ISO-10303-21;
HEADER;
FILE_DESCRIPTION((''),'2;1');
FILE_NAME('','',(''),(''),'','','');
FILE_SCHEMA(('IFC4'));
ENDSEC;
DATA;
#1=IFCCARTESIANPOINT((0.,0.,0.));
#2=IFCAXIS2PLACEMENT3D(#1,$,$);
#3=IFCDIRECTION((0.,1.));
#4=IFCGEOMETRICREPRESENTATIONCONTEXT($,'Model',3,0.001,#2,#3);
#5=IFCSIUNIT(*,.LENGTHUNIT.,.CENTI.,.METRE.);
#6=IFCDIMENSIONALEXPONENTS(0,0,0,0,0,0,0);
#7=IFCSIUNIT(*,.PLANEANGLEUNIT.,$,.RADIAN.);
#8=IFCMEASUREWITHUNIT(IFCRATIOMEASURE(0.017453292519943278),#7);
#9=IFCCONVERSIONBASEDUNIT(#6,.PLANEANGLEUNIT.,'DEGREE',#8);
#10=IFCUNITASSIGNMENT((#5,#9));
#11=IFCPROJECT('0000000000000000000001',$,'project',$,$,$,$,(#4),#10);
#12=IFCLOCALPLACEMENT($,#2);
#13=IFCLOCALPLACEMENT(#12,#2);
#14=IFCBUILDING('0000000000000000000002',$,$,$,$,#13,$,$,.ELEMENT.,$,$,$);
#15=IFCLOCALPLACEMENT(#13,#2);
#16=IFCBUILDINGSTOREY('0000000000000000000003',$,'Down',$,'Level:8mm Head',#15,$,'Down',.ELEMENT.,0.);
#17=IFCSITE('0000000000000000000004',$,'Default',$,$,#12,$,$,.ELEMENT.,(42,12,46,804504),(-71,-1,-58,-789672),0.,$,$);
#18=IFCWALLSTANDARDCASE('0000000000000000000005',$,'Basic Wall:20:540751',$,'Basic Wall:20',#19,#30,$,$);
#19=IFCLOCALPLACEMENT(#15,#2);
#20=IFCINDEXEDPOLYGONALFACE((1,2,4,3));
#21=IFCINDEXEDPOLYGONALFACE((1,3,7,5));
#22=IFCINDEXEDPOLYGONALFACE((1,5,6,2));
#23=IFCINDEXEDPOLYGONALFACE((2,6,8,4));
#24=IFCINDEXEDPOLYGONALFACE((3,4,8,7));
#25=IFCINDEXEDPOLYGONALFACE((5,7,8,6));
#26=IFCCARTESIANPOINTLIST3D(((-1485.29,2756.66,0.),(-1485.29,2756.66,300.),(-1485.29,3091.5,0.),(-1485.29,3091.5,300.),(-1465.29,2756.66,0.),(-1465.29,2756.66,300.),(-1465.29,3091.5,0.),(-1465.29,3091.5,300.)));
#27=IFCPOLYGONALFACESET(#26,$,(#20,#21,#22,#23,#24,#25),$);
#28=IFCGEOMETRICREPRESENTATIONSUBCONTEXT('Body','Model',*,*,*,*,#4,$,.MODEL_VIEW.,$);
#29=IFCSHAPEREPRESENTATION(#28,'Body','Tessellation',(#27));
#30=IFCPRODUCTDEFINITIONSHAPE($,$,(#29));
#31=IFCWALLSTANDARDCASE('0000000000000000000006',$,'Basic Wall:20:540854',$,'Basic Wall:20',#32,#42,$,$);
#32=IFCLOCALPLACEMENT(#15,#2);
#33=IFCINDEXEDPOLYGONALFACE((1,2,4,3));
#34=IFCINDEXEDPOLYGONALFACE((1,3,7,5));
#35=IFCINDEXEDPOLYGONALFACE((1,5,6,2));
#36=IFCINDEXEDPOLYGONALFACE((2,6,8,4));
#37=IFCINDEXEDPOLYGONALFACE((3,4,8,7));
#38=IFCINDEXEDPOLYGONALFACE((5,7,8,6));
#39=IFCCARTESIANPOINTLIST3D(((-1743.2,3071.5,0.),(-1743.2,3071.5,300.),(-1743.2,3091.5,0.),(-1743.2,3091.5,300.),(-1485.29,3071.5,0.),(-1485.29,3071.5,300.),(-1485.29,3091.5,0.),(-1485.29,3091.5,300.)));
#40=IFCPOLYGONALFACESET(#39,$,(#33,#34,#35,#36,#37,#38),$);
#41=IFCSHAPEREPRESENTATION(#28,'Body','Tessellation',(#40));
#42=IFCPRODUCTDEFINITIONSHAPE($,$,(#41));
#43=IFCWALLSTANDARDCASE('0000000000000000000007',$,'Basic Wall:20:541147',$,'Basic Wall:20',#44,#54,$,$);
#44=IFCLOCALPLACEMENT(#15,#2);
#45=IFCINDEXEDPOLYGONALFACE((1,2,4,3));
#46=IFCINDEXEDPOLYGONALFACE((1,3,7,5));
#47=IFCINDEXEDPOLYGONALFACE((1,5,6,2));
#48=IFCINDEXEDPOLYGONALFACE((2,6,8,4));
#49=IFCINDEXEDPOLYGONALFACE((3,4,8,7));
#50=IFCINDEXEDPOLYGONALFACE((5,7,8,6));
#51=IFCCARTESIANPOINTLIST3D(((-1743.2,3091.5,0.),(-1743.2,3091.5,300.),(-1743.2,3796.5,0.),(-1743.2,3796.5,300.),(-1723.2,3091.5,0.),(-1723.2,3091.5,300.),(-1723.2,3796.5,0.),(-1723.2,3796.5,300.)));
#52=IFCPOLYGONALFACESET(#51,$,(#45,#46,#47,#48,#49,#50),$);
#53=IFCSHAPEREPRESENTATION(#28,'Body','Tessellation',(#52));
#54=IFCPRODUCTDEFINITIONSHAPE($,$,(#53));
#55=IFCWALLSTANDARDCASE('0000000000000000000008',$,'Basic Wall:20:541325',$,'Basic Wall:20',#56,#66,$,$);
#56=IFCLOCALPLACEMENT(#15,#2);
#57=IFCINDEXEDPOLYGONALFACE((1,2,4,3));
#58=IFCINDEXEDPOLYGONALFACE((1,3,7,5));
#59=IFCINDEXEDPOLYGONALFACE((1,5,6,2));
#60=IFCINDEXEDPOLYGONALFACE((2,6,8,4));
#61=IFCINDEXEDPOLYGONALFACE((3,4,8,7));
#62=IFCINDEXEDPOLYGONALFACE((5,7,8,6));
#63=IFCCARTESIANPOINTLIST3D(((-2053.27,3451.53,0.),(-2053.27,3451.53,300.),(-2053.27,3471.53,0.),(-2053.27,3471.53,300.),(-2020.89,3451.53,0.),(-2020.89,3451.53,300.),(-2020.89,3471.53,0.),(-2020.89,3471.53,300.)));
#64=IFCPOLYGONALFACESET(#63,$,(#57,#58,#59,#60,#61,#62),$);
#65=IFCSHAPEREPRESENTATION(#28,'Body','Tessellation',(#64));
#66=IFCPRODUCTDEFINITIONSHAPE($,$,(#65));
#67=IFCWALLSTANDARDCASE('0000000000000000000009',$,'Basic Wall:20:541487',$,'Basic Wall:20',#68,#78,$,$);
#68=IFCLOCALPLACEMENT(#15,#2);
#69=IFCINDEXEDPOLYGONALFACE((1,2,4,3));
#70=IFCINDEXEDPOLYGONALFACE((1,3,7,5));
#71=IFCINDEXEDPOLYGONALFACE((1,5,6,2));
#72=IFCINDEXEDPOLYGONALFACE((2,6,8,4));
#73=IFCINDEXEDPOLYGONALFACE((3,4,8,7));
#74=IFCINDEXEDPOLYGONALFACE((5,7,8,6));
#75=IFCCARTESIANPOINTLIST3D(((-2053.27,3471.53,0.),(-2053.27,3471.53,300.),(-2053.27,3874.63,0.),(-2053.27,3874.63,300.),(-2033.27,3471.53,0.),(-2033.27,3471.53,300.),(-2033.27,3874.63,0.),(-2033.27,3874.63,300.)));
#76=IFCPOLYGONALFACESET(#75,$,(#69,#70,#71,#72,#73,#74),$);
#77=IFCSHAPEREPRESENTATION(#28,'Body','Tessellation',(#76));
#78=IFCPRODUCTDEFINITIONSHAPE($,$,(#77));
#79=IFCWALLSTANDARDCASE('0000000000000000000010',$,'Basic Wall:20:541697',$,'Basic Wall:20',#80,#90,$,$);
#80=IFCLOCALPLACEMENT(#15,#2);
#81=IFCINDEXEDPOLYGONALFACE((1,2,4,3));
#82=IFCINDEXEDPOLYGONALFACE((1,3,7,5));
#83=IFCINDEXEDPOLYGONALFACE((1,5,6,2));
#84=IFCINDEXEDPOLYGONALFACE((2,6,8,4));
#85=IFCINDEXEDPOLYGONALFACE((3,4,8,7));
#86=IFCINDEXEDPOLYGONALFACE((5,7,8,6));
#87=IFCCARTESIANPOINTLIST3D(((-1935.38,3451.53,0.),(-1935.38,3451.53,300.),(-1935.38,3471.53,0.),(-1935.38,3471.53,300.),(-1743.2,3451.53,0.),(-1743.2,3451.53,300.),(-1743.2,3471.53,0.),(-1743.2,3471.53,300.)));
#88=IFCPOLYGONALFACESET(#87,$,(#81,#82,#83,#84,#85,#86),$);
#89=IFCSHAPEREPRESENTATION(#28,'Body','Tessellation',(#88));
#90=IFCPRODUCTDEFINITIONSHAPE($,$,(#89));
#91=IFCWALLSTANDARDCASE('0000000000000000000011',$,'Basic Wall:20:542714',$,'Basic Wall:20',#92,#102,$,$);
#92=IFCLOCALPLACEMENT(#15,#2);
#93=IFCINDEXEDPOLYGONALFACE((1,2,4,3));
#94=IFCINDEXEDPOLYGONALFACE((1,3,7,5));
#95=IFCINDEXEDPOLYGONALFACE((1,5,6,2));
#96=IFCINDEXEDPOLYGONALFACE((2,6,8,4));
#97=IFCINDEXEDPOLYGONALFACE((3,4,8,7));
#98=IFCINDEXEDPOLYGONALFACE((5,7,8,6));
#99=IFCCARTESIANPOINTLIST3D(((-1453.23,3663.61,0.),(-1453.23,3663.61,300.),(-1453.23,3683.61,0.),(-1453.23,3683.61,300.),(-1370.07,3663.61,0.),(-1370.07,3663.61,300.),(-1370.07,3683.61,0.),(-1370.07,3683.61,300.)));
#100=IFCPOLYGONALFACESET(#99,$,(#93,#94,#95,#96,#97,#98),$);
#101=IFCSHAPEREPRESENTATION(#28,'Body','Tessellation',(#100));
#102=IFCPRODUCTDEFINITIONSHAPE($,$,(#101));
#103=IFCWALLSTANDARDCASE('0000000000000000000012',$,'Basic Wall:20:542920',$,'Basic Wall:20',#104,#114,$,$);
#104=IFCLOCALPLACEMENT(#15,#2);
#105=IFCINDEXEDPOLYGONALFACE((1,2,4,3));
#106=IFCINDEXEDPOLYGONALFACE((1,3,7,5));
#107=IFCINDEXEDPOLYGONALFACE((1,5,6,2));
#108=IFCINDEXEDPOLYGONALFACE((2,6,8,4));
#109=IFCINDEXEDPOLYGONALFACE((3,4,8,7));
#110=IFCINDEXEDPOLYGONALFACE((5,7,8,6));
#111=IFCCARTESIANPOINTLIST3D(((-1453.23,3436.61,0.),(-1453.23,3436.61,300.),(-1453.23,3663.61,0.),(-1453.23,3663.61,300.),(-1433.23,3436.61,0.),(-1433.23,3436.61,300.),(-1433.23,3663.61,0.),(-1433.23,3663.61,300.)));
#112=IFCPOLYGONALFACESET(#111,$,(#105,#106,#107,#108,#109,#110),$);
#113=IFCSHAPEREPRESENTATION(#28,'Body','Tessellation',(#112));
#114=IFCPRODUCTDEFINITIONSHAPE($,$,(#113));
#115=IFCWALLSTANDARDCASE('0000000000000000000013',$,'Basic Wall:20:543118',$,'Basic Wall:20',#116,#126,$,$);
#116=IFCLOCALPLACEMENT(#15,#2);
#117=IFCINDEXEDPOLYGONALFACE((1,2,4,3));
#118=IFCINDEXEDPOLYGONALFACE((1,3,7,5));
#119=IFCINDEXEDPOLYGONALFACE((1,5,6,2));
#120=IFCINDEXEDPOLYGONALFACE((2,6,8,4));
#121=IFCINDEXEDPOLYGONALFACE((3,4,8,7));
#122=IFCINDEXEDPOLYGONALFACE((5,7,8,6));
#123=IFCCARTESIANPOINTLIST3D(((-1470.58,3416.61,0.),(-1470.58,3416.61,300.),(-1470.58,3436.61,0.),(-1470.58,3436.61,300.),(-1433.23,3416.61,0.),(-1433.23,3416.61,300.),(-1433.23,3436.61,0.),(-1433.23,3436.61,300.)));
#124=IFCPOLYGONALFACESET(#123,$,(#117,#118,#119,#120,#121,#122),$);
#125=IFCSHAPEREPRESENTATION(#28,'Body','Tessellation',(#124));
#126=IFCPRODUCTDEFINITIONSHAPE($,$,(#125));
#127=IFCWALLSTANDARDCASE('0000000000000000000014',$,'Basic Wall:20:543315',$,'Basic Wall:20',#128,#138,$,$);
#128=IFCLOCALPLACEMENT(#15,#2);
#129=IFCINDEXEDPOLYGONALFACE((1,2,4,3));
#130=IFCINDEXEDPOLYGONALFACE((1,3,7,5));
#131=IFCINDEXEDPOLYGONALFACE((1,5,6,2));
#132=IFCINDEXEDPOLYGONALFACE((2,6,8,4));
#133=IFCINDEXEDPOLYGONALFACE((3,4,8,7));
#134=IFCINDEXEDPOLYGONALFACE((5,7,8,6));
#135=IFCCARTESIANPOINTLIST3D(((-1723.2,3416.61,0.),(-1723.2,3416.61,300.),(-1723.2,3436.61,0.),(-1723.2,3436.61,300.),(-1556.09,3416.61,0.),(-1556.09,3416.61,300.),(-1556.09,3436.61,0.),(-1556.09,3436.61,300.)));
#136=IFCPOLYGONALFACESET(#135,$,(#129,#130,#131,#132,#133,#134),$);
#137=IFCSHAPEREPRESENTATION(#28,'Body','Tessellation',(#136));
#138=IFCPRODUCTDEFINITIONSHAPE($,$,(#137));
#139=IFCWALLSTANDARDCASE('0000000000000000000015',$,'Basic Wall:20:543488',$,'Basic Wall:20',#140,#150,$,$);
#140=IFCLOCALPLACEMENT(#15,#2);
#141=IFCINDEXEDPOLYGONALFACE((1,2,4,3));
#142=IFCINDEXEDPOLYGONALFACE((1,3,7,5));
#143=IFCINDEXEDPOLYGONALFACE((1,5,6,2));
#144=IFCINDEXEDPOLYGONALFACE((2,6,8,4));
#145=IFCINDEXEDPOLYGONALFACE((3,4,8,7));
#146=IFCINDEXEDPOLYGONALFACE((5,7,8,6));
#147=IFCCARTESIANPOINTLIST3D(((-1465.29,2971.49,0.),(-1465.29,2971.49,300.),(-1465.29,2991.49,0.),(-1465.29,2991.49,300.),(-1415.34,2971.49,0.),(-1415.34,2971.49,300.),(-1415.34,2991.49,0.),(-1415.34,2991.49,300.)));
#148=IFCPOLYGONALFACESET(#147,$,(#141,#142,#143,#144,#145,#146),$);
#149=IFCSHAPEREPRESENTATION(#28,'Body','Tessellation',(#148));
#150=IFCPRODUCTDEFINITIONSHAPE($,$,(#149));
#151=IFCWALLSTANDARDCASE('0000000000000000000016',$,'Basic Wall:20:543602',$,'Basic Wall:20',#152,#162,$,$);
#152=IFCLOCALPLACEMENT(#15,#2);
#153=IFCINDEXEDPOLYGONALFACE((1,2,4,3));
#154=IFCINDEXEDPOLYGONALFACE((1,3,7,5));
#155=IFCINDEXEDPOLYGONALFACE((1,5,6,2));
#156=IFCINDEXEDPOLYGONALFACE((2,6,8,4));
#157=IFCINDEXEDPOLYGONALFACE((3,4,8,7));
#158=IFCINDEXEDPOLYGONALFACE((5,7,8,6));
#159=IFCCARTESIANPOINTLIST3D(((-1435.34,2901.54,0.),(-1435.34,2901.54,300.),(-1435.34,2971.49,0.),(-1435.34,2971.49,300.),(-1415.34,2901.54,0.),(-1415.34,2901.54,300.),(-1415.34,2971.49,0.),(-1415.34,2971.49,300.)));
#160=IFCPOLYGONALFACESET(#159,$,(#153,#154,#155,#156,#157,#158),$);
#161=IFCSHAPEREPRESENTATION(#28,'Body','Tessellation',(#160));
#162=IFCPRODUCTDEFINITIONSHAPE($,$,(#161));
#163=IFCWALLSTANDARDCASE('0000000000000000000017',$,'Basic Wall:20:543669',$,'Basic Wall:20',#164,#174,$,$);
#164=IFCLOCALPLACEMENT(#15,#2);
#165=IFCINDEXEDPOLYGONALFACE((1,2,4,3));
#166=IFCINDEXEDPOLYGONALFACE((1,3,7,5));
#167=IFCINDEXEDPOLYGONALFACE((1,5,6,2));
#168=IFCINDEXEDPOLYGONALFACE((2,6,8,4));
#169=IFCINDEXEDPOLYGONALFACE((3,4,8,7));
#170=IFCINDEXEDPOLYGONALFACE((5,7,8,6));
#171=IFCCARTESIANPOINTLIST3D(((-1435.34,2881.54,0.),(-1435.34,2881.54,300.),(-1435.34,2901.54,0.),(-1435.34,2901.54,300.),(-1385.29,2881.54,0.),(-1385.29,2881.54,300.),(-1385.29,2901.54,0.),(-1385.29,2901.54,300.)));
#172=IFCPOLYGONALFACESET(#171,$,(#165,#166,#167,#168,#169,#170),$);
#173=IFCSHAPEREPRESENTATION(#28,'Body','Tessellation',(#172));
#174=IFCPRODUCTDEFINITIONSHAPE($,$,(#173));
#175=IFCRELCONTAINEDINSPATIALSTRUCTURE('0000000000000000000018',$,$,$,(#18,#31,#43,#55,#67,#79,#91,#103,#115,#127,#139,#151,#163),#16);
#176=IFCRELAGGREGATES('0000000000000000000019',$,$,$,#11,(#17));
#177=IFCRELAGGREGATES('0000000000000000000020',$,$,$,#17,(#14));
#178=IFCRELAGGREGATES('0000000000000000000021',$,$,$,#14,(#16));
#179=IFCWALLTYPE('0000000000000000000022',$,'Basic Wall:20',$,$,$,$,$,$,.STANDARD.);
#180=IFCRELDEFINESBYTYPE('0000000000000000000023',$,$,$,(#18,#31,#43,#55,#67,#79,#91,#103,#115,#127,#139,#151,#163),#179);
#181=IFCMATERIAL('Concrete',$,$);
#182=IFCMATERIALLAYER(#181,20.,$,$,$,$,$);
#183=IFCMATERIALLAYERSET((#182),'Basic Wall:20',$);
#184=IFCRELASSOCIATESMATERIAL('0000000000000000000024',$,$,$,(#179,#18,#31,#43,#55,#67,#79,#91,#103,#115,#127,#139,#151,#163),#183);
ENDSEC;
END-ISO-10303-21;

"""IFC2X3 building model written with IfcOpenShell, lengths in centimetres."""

from ifc_helpers import new_model, entity, si_unit, converted_unit, direction, frame, frame_2d, origin, place, context, subcontext, project, spatial, rectangle, extrude, material, layer, layer_set, layer_usage, type_object, element, save


model = new_model("IFC2X3")

# Units and contexts
model_context = context("Model", 3, precision=0.001, world=origin(), true_north=direction((0.0, 1.0)))
body_context = subcontext(model_context, "Body", "Model", "MODEL_VIEW")
ifc_project = project(units=[si_unit("LENGTHUNIT", "METRE", prefix="CENTI"), converted_unit("PLANEANGLEUNIT", "DEGREE", entity("IfcRatioMeasure", 0.017453292519943278), si_unit("PLANEANGLEUNIT", "RADIAN"), dimensions=[0, 0, 0, 0, 0, 0, 0])], contexts=[model_context])

# Site, building, storey
site_placement = place(None, origin())
site = spatial("IfcSite", under=ifc_project, at=site_placement, Name="Default", CompositionType="ELEMENT", RefLatitude=(42, 12, 46, 804504), RefLongitude=(-71, -1, -58, -789672), RefElevation=0.0)
building_placement = place(site_placement, origin())
building = spatial("IfcBuilding", under=site, at=building_placement, CompositionType="ELEMENT")
storey_placement = place(building_placement, origin())
storey = spatial("IfcBuildingStorey", under=building, at=storey_placement, Name="Down", ObjectType="Level:8mm Head", LongName="Down", CompositionType="ELEMENT", Elevation=0.0)

# Walls
ifc_material = material(Name="Concrete")
ifc_layer_1 = layer(ifc_material, 20.0)
ifc_layer_set_1 = layer_set([ifc_layer_1], Name="Basic Wall:20")
ifc_layer_usage_1 = layer_usage(ifc_layer_set_1, "AXIS2", "POSITIVE", -10.0)
wall_type_1 = type_object("IfcWallType", Name="Basic Wall:20", PredefinedType="STANDARD", material=ifc_layer_set_1)
wall_1_placement = place(storey_placement, frame((-1475.29, 2756.66, 0.0), z_axis=(0.0, 0.0, 1.0), x_axis=(0.0, 1.0, 0.0)))
element("IfcWallStandardCase", 1, at=wall_1_placement, inside=storey, type_object=wall_type_1, material=ifc_layer_usage_1, Name="Basic Wall:20:540751", ObjectType="Basic Wall:20", context=body_context, shape_type="SweptSolid", body=[
    extrude(rectangle(XDim=334.84, YDim=20.0, at=frame_2d((167.42, 0.0), x_axis=(-1.0, 0.0))), origin(), (0.0, 0.0, 1.0), 300.0),
])
ifc_layer_usage_2 = layer_usage(ifc_layer_set_1, "AXIS2", "POSITIVE", -10.0)
wall_2_placement = place(storey_placement, frame((-1485.29, 3081.5, 0.0), z_axis=(0.0, 0.0, 1.0), x_axis=(-1.0, 0.0, 0.0)))
element("IfcWallStandardCase", 2, at=wall_2_placement, inside=storey, type_object=wall_type_1, material=ifc_layer_usage_2, Name="Basic Wall:20:540854", ObjectType="Basic Wall:20", context=body_context, shape_type="SweptSolid", body=[
    extrude(rectangle(XDim=257.9, YDim=20.0, at=frame_2d((128.95, 0.0), x_axis=(-1.0, 0.0))), origin(), (0.0, 0.0, 1.0), 300.0),
])
ifc_layer_usage_3 = layer_usage(ifc_layer_set_1, "AXIS2", "NEGATIVE", 10.0)
wall_3_placement = place(storey_placement, frame((-1733.2, 3091.5, 0.0), z_axis=(0.0, 0.0, 1.0), x_axis=(0.0, 1.0, 0.0)))
element("IfcWallStandardCase", 3, at=wall_3_placement, inside=storey, type_object=wall_type_1, material=ifc_layer_usage_3, Name="Basic Wall:20:541147", ObjectType="Basic Wall:20", context=body_context, shape_type="SweptSolid", body=[
    extrude(rectangle(XDim=705.0, YDim=20.0, at=frame_2d((352.5, 0.0), x_axis=(-1.0, 0.0))), origin(), (0.0, 0.0, 1.0), 300.0),
])
ifc_layer_usage_4 = layer_usage(ifc_layer_set_1, "AXIS2", "NEGATIVE", 10.0)
wall_4_placement = place(storey_placement, frame((-2020.89, 3461.53, 0.0), z_axis=(0.0, 0.0, 1.0), x_axis=(-1.0, 0.0, 0.0)))
element("IfcWallStandardCase", 4, at=wall_4_placement, inside=storey, type_object=wall_type_1, material=ifc_layer_usage_4, Name="Basic Wall:20:541325", ObjectType="Basic Wall:20", context=body_context, shape_type="SweptSolid", body=[
    extrude(rectangle(XDim=32.38, YDim=20.0, at=frame_2d((16.19, 0.0), x_axis=(-1.0, 0.0))), origin(), (0.0, 0.0, 1.0), 300.0),
])
ifc_layer_usage_5 = layer_usage(ifc_layer_set_1, "AXIS2", "NEGATIVE", 10.0)
wall_5_placement = place(storey_placement, frame((-2043.27, 3471.53, 0.0), z_axis=(0.0, 0.0, 1.0), x_axis=(0.0, 1.0, 0.0)))
element("IfcWallStandardCase", 5, at=wall_5_placement, inside=storey, type_object=wall_type_1, material=ifc_layer_usage_5, Name="Basic Wall:20:541487", ObjectType="Basic Wall:20", context=body_context, shape_type="SweptSolid", body=[
    extrude(rectangle(XDim=403.1, YDim=20.0, at=frame_2d((201.55, 0.0), x_axis=(-1.0, 0.0))), origin(), (0.0, 0.0, 1.0), 300.0),
])
ifc_layer_usage_6 = layer_usage(ifc_layer_set_1, "AXIS2", "POSITIVE", -10.0)
wall_6_placement = place(storey_placement, frame((-1935.38, 3461.53, 0.0)))
element("IfcWallStandardCase", 6, at=wall_6_placement, inside=storey, type_object=wall_type_1, material=ifc_layer_usage_6, Name="Basic Wall:20:541697", ObjectType="Basic Wall:20", context=body_context, shape_type="SweptSolid", body=[
    extrude(rectangle(XDim=192.18, YDim=20.0, at=frame_2d((96.09, 0.0), x_axis=(-1.0, 0.0))), origin(), (0.0, 0.0, 1.0), 300.0),
])
ifc_layer_usage_7 = layer_usage(ifc_layer_set_1, "AXIS2", "NEGATIVE", 10.0)
wall_7_placement = place(storey_placement, frame((-1370.07, 3673.61, 0.0), z_axis=(0.0, 0.0, 1.0), x_axis=(-1.0, 0.0, 0.0)))
element("IfcWallStandardCase", 7, at=wall_7_placement, inside=storey, type_object=wall_type_1, material=ifc_layer_usage_7, Name="Basic Wall:20:542714", ObjectType="Basic Wall:20", context=body_context, shape_type="SweptSolid", body=[
    extrude(rectangle(XDim=83.15, YDim=20.0, at=frame_2d((41.58, 0.0), x_axis=(-1.0, 0.0))), origin(), (0.0, 0.0, 1.0), 300.0),
])
ifc_layer_usage_8 = layer_usage(ifc_layer_set_1, "AXIS2", "POSITIVE", -10.0)
wall_8_placement = place(storey_placement, frame((-1443.23, 3663.61, 0.0), z_axis=(0.0, 0.0, 1.0), x_axis=(0.0, -1.0, 0.0)))
element("IfcWallStandardCase", 8, at=wall_8_placement, inside=storey, type_object=wall_type_1, material=ifc_layer_usage_8, Name="Basic Wall:20:542920", ObjectType="Basic Wall:20", context=body_context, shape_type="SweptSolid", body=[
    extrude(rectangle(XDim=227.0, YDim=20.0, at=frame_2d((113.5, 0.0), x_axis=(-1.0, 0.0))), origin(), (0.0, 0.0, 1.0), 300.0),
])
ifc_layer_usage_9 = layer_usage(ifc_layer_set_1, "AXIS2", "NEGATIVE", 10.0)
wall_9_placement = place(storey_placement, frame((-1433.23, 3426.61, 0.0), z_axis=(0.0, 0.0, 1.0), x_axis=(-1.0, 0.0, 0.0)))
element("IfcWallStandardCase", 9, at=wall_9_placement, inside=storey, type_object=wall_type_1, material=ifc_layer_usage_9, Name="Basic Wall:20:543118", ObjectType="Basic Wall:20", context=body_context, shape_type="SweptSolid", body=[
    extrude(rectangle(XDim=37.36, YDim=20.0, at=frame_2d((18.68, 0.0), x_axis=(-1.0, 0.0))), origin(), (0.0, 0.0, 1.0), 300.0),
])
ifc_layer_usage_10 = layer_usage(ifc_layer_set_1, "AXIS2", "NEGATIVE", 10.0)
wall_10_placement = place(storey_placement, frame((-1556.09, 3426.61, 0.0), z_axis=(0.0, 0.0, 1.0), x_axis=(-1.0, 0.0, 0.0)))
element("IfcWallStandardCase", 10, at=wall_10_placement, inside=storey, type_object=wall_type_1, material=ifc_layer_usage_10, Name="Basic Wall:20:543315", ObjectType="Basic Wall:20", context=body_context, shape_type="SweptSolid", body=[
    extrude(rectangle(XDim=167.1, YDim=20.0, at=frame_2d((83.55, 0.0), x_axis=(-1.0, 0.0))), origin(), (0.0, 0.0, 1.0), 300.0),
])
ifc_layer_usage_11 = layer_usage(ifc_layer_set_1, "AXIS2", "POSITIVE", -10.0)
wall_11_placement = place(storey_placement, frame((-1465.29, 2981.49, 0.0)))
element("IfcWallStandardCase", 11, at=wall_11_placement, inside=storey, type_object=wall_type_1, material=ifc_layer_usage_11, Name="Basic Wall:20:543488", ObjectType="Basic Wall:20", context=body_context, shape_type="SweptSolid", body=[
    extrude(rectangle(XDim=49.95, YDim=20.0, at=frame_2d((24.98, 0.0), x_axis=(-1.0, 0.0))), origin(), (0.0, 0.0, 1.0), 300.0),
])
ifc_layer_usage_12 = layer_usage(ifc_layer_set_1, "AXIS2", "NEGATIVE", 10.0)
wall_12_placement = place(storey_placement, frame((-1425.34, 2971.49, 0.0), z_axis=(0.0, 0.0, 1.0), x_axis=(0.0, -1.0, 0.0)))
element("IfcWallStandardCase", 12, at=wall_12_placement, inside=storey, type_object=wall_type_1, material=ifc_layer_usage_12, Name="Basic Wall:20:543602", ObjectType="Basic Wall:20", context=body_context, shape_type="SweptSolid", body=[
    extrude(rectangle(XDim=69.95, YDim=20.0, at=frame_2d((34.98, 0.0), x_axis=(-1.0, 0.0))), origin(), (0.0, 0.0, 1.0), 300.0),
])
ifc_layer_usage_13 = layer_usage(ifc_layer_set_1, "AXIS2", "POSITIVE", -10.0)
wall_13_placement = place(storey_placement, frame((-1435.34, 2891.54, 0.0)))
element("IfcWallStandardCase", 13, at=wall_13_placement, inside=storey, type_object=wall_type_1, material=ifc_layer_usage_13, Name="Basic Wall:20:543669", ObjectType="Basic Wall:20", context=body_context, shape_type="SweptSolid", body=[
    extrude(rectangle(XDim=50.05, YDim=20.0, at=frame_2d((25.03, 0.0), x_axis=(-1.0, 0.0))), origin(), (0.0, 0.0, 1.0), 300.0),
])

save(model, "model.ifc")
